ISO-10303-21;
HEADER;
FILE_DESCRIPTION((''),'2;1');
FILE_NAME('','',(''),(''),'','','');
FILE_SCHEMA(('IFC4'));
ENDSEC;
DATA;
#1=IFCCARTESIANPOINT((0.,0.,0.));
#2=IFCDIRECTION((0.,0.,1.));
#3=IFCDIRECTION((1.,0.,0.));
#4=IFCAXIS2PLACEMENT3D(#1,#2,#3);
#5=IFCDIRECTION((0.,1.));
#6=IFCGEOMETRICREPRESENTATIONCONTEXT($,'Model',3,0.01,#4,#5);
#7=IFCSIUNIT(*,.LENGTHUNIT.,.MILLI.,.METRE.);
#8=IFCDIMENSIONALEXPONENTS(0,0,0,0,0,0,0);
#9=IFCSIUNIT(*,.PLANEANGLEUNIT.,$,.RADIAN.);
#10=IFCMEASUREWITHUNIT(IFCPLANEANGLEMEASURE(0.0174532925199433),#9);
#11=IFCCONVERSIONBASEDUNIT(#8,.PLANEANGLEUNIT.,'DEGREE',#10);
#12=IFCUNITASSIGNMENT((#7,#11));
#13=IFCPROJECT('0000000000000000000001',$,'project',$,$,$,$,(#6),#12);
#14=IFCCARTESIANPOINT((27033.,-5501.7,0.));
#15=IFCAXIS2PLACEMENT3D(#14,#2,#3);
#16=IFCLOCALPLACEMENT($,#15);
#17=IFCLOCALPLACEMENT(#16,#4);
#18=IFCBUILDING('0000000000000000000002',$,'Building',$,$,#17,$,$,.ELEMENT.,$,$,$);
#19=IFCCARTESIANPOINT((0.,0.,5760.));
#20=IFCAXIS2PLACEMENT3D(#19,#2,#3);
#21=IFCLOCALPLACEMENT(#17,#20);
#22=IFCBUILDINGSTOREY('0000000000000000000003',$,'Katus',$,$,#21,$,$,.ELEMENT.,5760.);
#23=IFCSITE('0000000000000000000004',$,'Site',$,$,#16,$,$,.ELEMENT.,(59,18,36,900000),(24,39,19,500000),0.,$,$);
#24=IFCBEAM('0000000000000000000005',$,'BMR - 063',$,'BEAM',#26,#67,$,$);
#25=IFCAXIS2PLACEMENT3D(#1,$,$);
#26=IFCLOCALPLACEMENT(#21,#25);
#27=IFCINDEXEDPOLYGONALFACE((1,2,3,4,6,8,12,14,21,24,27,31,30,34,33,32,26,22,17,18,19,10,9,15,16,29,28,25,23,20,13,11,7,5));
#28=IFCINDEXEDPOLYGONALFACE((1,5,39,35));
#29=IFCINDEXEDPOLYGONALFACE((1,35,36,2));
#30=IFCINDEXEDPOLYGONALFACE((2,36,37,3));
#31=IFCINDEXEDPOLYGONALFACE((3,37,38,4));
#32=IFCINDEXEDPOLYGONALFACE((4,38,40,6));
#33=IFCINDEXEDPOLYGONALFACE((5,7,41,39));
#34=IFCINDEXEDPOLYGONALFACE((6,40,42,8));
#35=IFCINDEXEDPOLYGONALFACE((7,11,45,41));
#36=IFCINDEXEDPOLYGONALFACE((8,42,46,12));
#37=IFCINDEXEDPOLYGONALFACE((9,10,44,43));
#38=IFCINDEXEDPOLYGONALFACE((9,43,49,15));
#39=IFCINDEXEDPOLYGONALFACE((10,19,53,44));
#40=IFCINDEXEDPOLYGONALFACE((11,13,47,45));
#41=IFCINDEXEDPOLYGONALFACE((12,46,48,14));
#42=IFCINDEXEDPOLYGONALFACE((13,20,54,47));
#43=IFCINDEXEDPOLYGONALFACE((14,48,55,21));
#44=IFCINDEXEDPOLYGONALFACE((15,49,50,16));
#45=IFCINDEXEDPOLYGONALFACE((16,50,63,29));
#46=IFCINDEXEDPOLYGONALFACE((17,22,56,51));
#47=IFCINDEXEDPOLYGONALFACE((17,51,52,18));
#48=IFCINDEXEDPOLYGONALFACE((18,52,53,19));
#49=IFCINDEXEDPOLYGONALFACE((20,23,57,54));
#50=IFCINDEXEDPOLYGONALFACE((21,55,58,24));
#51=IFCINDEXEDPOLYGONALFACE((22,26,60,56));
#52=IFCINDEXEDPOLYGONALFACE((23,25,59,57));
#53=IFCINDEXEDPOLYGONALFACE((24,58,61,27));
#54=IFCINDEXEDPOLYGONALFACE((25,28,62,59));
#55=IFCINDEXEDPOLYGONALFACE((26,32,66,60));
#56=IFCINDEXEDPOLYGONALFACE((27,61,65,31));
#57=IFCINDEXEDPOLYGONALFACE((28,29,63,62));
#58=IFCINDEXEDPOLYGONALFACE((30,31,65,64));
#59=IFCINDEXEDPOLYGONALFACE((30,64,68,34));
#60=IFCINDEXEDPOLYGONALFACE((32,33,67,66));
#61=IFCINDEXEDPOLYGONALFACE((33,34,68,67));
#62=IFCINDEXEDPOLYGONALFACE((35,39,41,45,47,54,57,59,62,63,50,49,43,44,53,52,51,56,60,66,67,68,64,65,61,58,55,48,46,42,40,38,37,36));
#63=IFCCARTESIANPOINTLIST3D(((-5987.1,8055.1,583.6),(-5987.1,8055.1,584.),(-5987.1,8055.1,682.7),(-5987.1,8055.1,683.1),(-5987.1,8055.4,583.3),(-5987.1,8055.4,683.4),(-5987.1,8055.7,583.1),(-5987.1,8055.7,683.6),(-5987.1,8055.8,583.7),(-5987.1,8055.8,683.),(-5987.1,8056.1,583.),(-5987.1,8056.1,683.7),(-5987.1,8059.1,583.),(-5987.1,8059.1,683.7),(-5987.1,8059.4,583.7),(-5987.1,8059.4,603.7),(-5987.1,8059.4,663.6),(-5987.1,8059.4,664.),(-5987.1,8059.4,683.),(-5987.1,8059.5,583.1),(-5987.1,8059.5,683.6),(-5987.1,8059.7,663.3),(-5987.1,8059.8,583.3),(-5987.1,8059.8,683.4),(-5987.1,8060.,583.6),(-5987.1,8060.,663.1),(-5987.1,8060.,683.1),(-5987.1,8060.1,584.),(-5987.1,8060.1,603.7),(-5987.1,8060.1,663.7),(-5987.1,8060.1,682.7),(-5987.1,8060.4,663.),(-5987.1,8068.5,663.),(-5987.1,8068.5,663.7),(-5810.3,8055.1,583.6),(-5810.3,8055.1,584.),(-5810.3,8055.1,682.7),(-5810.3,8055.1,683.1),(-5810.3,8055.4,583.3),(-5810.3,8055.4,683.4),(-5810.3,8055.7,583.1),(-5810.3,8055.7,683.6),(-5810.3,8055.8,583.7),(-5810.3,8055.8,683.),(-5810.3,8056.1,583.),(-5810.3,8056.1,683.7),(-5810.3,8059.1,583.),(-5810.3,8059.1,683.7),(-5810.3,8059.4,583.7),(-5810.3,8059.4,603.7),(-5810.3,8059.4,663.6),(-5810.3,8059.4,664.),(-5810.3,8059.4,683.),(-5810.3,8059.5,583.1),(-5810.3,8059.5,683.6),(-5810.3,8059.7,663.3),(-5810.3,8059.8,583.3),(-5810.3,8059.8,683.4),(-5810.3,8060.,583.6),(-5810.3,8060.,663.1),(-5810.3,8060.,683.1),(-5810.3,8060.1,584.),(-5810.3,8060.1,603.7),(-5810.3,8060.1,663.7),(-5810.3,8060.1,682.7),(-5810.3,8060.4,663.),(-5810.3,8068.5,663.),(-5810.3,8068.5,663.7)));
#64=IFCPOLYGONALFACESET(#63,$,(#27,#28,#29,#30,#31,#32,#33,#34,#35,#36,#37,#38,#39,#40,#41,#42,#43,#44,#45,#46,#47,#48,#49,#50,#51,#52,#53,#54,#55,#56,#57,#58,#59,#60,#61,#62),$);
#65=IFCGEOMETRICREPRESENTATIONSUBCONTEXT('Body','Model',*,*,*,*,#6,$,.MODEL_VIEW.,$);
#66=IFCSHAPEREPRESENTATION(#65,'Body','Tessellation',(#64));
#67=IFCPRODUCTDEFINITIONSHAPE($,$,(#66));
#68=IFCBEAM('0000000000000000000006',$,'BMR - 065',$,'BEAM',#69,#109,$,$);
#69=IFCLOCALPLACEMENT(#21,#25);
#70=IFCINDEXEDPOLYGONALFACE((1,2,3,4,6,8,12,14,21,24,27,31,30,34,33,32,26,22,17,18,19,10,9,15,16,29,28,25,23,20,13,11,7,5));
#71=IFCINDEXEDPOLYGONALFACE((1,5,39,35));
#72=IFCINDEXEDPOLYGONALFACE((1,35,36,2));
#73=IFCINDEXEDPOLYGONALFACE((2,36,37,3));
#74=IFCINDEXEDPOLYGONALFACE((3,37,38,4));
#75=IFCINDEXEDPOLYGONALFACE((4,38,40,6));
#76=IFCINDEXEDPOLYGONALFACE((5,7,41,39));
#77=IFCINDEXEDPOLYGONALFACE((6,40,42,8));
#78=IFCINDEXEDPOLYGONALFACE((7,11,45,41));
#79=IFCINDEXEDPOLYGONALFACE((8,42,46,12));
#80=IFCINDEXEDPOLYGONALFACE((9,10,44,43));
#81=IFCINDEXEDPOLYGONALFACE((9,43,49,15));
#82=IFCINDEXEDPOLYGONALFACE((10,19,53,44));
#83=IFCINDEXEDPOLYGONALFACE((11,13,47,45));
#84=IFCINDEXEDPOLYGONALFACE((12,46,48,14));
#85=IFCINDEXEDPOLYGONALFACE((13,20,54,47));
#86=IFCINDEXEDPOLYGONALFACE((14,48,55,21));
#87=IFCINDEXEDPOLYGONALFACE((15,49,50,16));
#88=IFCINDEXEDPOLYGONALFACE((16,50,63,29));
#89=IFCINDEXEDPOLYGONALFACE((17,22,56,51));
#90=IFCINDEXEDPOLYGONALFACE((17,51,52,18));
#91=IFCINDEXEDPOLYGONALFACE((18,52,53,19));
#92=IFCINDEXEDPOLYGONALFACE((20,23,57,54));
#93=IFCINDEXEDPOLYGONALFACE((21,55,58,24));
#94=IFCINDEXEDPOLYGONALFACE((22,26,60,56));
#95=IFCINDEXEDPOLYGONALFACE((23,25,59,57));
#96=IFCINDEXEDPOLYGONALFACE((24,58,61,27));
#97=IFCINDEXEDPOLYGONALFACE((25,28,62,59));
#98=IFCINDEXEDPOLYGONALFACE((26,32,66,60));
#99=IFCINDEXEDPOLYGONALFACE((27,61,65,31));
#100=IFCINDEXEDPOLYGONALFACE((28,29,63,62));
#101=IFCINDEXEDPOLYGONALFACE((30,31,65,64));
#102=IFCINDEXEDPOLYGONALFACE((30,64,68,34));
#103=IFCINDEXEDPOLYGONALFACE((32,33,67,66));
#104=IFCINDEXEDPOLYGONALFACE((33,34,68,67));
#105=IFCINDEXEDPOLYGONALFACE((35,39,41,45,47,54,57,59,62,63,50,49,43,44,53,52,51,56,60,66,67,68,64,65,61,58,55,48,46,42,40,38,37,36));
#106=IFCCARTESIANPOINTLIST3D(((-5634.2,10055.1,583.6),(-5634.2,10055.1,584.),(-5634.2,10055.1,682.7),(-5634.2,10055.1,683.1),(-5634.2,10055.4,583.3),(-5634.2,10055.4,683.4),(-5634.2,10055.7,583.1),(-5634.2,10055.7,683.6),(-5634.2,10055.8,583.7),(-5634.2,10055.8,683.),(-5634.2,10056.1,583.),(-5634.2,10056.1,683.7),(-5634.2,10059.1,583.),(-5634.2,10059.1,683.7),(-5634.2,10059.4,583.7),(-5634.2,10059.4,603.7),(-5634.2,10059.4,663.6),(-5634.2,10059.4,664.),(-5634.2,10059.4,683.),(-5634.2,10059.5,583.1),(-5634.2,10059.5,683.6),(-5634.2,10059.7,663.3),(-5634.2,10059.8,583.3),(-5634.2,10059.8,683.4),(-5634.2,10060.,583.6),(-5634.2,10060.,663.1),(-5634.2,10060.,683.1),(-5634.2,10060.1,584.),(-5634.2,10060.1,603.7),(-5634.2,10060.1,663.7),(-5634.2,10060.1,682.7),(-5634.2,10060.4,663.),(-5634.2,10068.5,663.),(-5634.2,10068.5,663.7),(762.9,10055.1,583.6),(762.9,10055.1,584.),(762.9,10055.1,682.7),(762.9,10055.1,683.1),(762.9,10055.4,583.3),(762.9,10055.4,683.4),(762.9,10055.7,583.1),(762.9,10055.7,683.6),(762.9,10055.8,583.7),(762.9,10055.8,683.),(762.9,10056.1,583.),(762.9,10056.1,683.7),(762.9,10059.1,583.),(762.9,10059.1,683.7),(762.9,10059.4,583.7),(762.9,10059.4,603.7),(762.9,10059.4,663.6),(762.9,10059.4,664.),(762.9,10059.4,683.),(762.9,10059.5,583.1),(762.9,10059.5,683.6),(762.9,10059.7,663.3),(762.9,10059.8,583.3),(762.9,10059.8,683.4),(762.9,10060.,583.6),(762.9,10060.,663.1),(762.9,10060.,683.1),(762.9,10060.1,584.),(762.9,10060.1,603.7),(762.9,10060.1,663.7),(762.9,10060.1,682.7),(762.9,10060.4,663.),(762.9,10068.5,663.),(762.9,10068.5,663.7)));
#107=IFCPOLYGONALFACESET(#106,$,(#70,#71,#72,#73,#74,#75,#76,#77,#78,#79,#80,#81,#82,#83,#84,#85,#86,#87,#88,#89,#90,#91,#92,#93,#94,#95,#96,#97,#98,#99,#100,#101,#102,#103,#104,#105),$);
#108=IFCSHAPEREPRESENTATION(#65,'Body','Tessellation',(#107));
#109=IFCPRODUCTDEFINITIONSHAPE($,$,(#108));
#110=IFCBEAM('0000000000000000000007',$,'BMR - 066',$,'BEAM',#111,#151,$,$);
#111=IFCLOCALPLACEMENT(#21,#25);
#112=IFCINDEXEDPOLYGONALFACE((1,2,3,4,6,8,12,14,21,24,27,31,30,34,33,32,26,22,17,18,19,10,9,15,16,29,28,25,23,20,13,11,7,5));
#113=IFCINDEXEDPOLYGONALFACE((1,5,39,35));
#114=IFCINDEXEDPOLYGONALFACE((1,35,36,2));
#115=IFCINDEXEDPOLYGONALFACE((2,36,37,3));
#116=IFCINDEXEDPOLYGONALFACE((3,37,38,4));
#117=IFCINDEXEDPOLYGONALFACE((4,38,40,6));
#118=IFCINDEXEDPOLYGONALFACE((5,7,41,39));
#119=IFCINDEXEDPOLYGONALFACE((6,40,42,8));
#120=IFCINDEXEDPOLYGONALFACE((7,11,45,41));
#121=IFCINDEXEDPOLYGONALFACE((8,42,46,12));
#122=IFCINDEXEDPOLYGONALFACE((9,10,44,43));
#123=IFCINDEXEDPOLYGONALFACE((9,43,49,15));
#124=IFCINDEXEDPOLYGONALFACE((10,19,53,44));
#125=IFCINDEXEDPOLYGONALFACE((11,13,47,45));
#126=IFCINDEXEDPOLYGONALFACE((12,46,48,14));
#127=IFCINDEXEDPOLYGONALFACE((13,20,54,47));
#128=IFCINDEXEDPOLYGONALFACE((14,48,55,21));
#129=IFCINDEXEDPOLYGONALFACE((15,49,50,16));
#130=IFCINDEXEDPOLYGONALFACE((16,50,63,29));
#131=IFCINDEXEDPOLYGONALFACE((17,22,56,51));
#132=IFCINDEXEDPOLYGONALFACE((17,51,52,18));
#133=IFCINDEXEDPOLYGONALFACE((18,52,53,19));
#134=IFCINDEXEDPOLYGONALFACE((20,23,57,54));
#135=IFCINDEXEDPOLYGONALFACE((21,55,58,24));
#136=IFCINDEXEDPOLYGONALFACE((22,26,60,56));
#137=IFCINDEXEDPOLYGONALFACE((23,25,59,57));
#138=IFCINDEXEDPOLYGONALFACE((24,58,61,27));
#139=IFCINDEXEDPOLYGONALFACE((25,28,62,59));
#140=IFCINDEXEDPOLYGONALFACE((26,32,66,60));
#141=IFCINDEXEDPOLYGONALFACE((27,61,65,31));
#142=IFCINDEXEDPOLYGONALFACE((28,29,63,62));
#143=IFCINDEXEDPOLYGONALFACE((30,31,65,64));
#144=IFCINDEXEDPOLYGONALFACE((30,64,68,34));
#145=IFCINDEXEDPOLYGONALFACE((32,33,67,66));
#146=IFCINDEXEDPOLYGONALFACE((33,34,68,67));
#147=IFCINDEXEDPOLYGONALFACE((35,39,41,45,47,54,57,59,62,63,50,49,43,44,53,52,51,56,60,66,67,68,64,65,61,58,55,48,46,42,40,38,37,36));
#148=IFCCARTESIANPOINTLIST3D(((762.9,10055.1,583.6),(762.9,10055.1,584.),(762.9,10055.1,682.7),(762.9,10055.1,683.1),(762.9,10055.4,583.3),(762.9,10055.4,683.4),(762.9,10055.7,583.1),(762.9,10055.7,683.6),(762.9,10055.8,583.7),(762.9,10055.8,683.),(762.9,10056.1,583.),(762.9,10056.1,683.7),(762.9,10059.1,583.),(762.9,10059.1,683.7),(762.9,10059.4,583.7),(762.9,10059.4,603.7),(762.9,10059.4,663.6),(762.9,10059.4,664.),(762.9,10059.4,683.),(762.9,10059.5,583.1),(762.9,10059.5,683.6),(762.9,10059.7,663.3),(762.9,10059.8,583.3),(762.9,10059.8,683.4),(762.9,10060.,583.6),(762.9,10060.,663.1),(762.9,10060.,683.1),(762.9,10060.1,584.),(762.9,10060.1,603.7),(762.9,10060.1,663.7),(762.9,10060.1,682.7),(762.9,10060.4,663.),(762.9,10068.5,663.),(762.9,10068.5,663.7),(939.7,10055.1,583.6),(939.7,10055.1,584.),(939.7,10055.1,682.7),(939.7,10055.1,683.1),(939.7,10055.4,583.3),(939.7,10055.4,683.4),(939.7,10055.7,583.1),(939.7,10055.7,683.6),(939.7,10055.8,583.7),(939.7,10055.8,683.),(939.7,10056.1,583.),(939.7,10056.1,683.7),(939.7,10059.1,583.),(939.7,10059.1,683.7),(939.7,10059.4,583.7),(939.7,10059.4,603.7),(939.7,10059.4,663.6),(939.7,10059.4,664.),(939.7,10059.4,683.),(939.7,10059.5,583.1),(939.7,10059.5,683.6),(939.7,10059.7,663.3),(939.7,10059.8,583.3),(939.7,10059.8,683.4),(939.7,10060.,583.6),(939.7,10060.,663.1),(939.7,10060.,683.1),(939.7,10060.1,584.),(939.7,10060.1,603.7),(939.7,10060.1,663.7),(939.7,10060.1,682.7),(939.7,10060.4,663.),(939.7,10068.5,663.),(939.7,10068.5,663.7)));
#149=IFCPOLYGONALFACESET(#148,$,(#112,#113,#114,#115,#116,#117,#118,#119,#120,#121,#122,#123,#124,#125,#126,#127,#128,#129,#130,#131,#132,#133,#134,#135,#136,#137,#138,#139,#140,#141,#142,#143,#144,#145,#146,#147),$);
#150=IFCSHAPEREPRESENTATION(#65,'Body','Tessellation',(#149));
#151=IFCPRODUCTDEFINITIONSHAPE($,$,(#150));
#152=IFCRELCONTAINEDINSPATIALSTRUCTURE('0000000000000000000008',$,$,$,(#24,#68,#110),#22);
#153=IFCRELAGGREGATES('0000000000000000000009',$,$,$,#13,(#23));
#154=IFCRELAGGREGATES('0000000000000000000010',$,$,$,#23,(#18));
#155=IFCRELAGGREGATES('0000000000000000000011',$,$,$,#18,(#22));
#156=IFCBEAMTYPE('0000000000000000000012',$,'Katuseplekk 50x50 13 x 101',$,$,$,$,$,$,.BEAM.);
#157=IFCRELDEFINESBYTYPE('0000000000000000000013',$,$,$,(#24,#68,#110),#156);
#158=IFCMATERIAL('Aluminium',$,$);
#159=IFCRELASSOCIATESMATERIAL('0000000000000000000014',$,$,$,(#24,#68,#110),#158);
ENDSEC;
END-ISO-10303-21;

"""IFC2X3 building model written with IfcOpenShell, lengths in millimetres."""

from ifc_helpers import new_model, entity, si_unit, converted_unit, point, direction, frame, frame_2d, origin_with_axes, place, context, subcontext, project, spatial, polyline, circle_curve, parameter, trimmed, segment, composite_curve, outline, extrude, material, type_object, element, save


model = new_model("IFC2X3")

# Units and contexts
model_context = context("Model", 3, precision=0.01, world=origin_with_axes(), true_north=direction((0.0, 1.0)))
body_context = subcontext(model_context, "Body", "Model", "MODEL_VIEW")
ifc_project = project(units=[si_unit("LENGTHUNIT", "METRE", prefix="MILLI"), converted_unit("PLANEANGLEUNIT", "DEGREE", entity("IfcPlaneAngleMeasure", 0.0174532925199433), si_unit("PLANEANGLEUNIT", "RADIAN"), dimensions=[0, 0, 0, 0, 0, 0, 0])], contexts=[model_context])

# Site, building, storey
site_placement = place(None, frame((27033.0, -5501.7, 0.0), z_axis=(0.0, 0.0, 1.0), x_axis=(1.0, 0.0, 0.0)))
site = spatial("IfcSite", under=ifc_project, at=site_placement, Name="Site", CompositionType="ELEMENT", RefLatitude=(59, 18, 36, 900000), RefLongitude=(24, 39, 19, 500000), RefElevation=0.0)
building_placement = place(site_placement, origin_with_axes())
building = spatial("IfcBuilding", under=site, at=building_placement, Name="Building", CompositionType="ELEMENT")
storey_placement = place(building_placement, frame((0.0, 0.0, 5760.0), z_axis=(0.0, 0.0, 1.0), x_axis=(1.0, 0.0, 0.0)))
storey = spatial("IfcBuildingStorey", under=building, at=storey_placement, Name="Katus", CompositionType="ELEMENT", Elevation=5760.0)

# Beams
ifc_material_1 = material(Name="Aluminium")
beam_type = type_object("IfcBeamType", Name="Katuseplekk 50x50 13 x 101", PredefinedType="BEAM")
beam_1_placement = place(storey_placement, frame((-5987.1, 8067.8, 663.0), z_axis=(0.0, 0.0, 1.0), x_axis=(0.0, -1.0, 0.0)))
element("IfcBeam", 1, at=beam_1_placement, inside=storey, type_object=beam_type, material=ifc_material_1, Name="BMR - 063", ObjectType="BEAM", context=body_context, shape_type="SweptSolid", body=[
    extrude(outline(composite_curve([segment(polyline([(-0.7, 0.0), (7.4, 0.0)]), True, "CONTINUOUS"), segment(trimmed(circle_curve(frame_2d((7.4, 1.0), x_axis=(0.0, -1.0)), 1.0), [point((7.4, 0.0)), parameter(0.0)], [point((8.4, 1.0)), parameter(90.0)], True, "CARTESIAN"), True, "CONTINUOUS"), segment(polyline([(8.4, 1.0), (8.4, 20.0), (12.0, 20.0), (12.0, -79.3), (8.4, -79.3), (8.4, -59.3), (7.7, -59.3), (7.7, -79.0)]), True, "CONTINUOUS"), segment(trimmed(circle_curve(frame_2d((8.7, -79.0), x_axis=(-1.0, 0.0)), 1.0), [point((7.7, -79.0)), parameter(0.0)], [point((8.7, -80.0)), parameter(90.0)], True, "CARTESIAN"), True, "CONTINUOUS"), segment(polyline([(8.7, -80.0), (11.7, -80.0)]), True, "CONTINUOUS"), segment(trimmed(circle_curve(frame_2d((11.7, -79.0), x_axis=(0.0, -1.0)), 1.0), [point((11.7, -80.0)), parameter(0.0)], [point((12.7, -79.0)), parameter(90.0)], True, "CARTESIAN"), True, "CONTINUOUS"), segment(polyline([(12.7, -79.0), (12.7, 19.7)]), True, "CONTINUOUS"), segment(trimmed(circle_curve(frame_2d((11.7, 19.7), x_axis=(1.0, 0.0)), 1.0), [point((12.7, 19.7)), parameter(0.0)], [point((11.7, 20.7)), parameter(90.0)], True, "CARTESIAN"), True, "CONTINUOUS"), segment(polyline([(11.7, 20.7), (8.7, 20.7)]), True, "CONTINUOUS"), segment(trimmed(circle_curve(frame_2d((8.7, 19.7), x_axis=(0.0, 1.0)), 1.0), [point((8.7, 20.7)), parameter(0.0)], [point((7.7, 19.7)), parameter(90.0)], True, "CARTESIAN"), True, "CONTINUOUS"), segment(polyline([(7.7, 19.7), (7.7, 0.7), (-0.7, 0.7), (-0.7, 0.0)]), True, "CONTINUOUS")], self_intersect=False)), frame((0.0, 176.8, 0.0), z_axis=(0.0, -1.0, 0.0), x_axis=(1.0, 0.0, 0.0)), (0.0, 0.0, 1.0), 176.8),
])
beam_2_placement = place(storey_placement, frame((-5634.2, 10067.8, 663.0), z_axis=(0.0, 0.0, 1.0), x_axis=(0.0, -1.0, 0.0)))
element("IfcBeam", 2, at=beam_2_placement, inside=storey, type_object=beam_type, material=ifc_material_1, Name="BMR - 065", ObjectType="BEAM", context=body_context, shape_type="SweptSolid", body=[
    extrude(outline(composite_curve([segment(polyline([(-0.7, 0.0), (7.4, 0.0)]), True, "CONTINUOUS"), segment(trimmed(circle_curve(frame_2d((7.4, 1.0), x_axis=(0.0, -1.0)), 1.0), [point((7.4, 0.0)), parameter(0.0)], [point((8.4, 1.0)), parameter(90.0)], True, "CARTESIAN"), True, "CONTINUOUS"), segment(polyline([(8.4, 1.0), (8.4, 20.0), (12.0, 20.0), (12.0, -79.3), (8.4, -79.3), (8.4, -59.3), (7.7, -59.3), (7.7, -79.0)]), True, "CONTINUOUS"), segment(trimmed(circle_curve(frame_2d((8.7, -79.0), x_axis=(-1.0, 0.0)), 1.0), [point((7.7, -79.0)), parameter(0.0)], [point((8.7, -80.0)), parameter(90.0)], True, "CARTESIAN"), True, "CONTINUOUS"), segment(polyline([(8.7, -80.0), (11.7, -80.0)]), True, "CONTINUOUS"), segment(trimmed(circle_curve(frame_2d((11.7, -79.0), x_axis=(0.0, -1.0)), 1.0), [point((11.7, -80.0)), parameter(0.0)], [point((12.7, -79.0)), parameter(90.0)], True, "CARTESIAN"), True, "CONTINUOUS"), segment(polyline([(12.7, -79.0), (12.7, 19.7)]), True, "CONTINUOUS"), segment(trimmed(circle_curve(frame_2d((11.7, 19.7), x_axis=(1.0, 0.0)), 1.0), [point((12.7, 19.7)), parameter(0.0)], [point((11.7, 20.7)), parameter(90.0)], True, "CARTESIAN"), True, "CONTINUOUS"), segment(polyline([(11.7, 20.7), (8.7, 20.7)]), True, "CONTINUOUS"), segment(trimmed(circle_curve(frame_2d((8.7, 19.7), x_axis=(0.0, 1.0)), 1.0), [point((8.7, 20.7)), parameter(0.0)], [point((7.7, 19.7)), parameter(90.0)], True, "CARTESIAN"), True, "CONTINUOUS"), segment(polyline([(7.7, 19.7), (7.7, 0.7), (-0.7, 0.7), (-0.7, 0.0)]), True, "CONTINUOUS")], self_intersect=False)), frame((0.0, 6397.1, 0.0), z_axis=(0.0, -1.0, 0.0), x_axis=(1.0, 0.0, 0.0)), (0.0, 0.0, 1.0), 6397.1),
])
beam_3_placement = place(storey_placement, frame((762.9, 10067.8, 663.0), z_axis=(0.0, 0.0, 1.0), x_axis=(0.0, -1.0, 0.0)))
element("IfcBeam", 3, at=beam_3_placement, inside=storey, type_object=beam_type, material=ifc_material_1, Name="BMR - 066", ObjectType="BEAM", context=body_context, shape_type="SweptSolid", body=[
    extrude(outline(composite_curve([segment(polyline([(-0.7, 0.0), (7.4, 0.0)]), True, "CONTINUOUS"), segment(trimmed(circle_curve(frame_2d((7.4, 1.0), x_axis=(0.0, -1.0)), 1.0), [point((7.4, 0.0)), parameter(0.0)], [point((8.4, 1.0)), parameter(90.0)], True, "CARTESIAN"), True, "CONTINUOUS"), segment(polyline([(8.4, 1.0), (8.4, 20.0), (12.0, 20.0), (12.0, -79.3), (8.4, -79.3), (8.4, -59.3), (7.7, -59.3), (7.7, -79.0)]), True, "CONTINUOUS"), segment(trimmed(circle_curve(frame_2d((8.7, -79.0), x_axis=(-1.0, 0.0)), 1.0), [point((7.7, -79.0)), parameter(0.0)], [point((8.7, -80.0)), parameter(90.0)], True, "CARTESIAN"), True, "CONTINUOUS"), segment(polyline([(8.7, -80.0), (11.7, -80.0)]), True, "CONTINUOUS"), segment(trimmed(circle_curve(frame_2d((11.7, -79.0), x_axis=(0.0, -1.0)), 1.0), [point((11.7, -80.0)), parameter(0.0)], [point((12.7, -79.0)), parameter(90.0)], True, "CARTESIAN"), True, "CONTINUOUS"), segment(polyline([(12.7, -79.0), (12.7, 19.7)]), True, "CONTINUOUS"), segment(trimmed(circle_curve(frame_2d((11.7, 19.7), x_axis=(1.0, 0.0)), 1.0), [point((12.7, 19.7)), parameter(0.0)], [point((11.7, 20.7)), parameter(90.0)], True, "CARTESIAN"), True, "CONTINUOUS"), segment(polyline([(11.7, 20.7), (8.7, 20.7)]), True, "CONTINUOUS"), segment(trimmed(circle_curve(frame_2d((8.7, 19.7), x_axis=(0.0, 1.0)), 1.0), [point((8.7, 20.7)), parameter(0.0)], [point((7.7, 19.7)), parameter(90.0)], True, "CARTESIAN"), True, "CONTINUOUS"), segment(polyline([(7.7, 19.7), (7.7, 0.7), (-0.7, 0.7), (-0.7, 0.0)]), True, "CONTINUOUS")], self_intersect=False)), frame((0.0, 176.8, 0.0), z_axis=(0.0, -1.0, 0.0), x_axis=(1.0, 0.0, 0.0)), (0.0, 0.0, 1.0), 176.8),
])

save(model, "model.ifc")
